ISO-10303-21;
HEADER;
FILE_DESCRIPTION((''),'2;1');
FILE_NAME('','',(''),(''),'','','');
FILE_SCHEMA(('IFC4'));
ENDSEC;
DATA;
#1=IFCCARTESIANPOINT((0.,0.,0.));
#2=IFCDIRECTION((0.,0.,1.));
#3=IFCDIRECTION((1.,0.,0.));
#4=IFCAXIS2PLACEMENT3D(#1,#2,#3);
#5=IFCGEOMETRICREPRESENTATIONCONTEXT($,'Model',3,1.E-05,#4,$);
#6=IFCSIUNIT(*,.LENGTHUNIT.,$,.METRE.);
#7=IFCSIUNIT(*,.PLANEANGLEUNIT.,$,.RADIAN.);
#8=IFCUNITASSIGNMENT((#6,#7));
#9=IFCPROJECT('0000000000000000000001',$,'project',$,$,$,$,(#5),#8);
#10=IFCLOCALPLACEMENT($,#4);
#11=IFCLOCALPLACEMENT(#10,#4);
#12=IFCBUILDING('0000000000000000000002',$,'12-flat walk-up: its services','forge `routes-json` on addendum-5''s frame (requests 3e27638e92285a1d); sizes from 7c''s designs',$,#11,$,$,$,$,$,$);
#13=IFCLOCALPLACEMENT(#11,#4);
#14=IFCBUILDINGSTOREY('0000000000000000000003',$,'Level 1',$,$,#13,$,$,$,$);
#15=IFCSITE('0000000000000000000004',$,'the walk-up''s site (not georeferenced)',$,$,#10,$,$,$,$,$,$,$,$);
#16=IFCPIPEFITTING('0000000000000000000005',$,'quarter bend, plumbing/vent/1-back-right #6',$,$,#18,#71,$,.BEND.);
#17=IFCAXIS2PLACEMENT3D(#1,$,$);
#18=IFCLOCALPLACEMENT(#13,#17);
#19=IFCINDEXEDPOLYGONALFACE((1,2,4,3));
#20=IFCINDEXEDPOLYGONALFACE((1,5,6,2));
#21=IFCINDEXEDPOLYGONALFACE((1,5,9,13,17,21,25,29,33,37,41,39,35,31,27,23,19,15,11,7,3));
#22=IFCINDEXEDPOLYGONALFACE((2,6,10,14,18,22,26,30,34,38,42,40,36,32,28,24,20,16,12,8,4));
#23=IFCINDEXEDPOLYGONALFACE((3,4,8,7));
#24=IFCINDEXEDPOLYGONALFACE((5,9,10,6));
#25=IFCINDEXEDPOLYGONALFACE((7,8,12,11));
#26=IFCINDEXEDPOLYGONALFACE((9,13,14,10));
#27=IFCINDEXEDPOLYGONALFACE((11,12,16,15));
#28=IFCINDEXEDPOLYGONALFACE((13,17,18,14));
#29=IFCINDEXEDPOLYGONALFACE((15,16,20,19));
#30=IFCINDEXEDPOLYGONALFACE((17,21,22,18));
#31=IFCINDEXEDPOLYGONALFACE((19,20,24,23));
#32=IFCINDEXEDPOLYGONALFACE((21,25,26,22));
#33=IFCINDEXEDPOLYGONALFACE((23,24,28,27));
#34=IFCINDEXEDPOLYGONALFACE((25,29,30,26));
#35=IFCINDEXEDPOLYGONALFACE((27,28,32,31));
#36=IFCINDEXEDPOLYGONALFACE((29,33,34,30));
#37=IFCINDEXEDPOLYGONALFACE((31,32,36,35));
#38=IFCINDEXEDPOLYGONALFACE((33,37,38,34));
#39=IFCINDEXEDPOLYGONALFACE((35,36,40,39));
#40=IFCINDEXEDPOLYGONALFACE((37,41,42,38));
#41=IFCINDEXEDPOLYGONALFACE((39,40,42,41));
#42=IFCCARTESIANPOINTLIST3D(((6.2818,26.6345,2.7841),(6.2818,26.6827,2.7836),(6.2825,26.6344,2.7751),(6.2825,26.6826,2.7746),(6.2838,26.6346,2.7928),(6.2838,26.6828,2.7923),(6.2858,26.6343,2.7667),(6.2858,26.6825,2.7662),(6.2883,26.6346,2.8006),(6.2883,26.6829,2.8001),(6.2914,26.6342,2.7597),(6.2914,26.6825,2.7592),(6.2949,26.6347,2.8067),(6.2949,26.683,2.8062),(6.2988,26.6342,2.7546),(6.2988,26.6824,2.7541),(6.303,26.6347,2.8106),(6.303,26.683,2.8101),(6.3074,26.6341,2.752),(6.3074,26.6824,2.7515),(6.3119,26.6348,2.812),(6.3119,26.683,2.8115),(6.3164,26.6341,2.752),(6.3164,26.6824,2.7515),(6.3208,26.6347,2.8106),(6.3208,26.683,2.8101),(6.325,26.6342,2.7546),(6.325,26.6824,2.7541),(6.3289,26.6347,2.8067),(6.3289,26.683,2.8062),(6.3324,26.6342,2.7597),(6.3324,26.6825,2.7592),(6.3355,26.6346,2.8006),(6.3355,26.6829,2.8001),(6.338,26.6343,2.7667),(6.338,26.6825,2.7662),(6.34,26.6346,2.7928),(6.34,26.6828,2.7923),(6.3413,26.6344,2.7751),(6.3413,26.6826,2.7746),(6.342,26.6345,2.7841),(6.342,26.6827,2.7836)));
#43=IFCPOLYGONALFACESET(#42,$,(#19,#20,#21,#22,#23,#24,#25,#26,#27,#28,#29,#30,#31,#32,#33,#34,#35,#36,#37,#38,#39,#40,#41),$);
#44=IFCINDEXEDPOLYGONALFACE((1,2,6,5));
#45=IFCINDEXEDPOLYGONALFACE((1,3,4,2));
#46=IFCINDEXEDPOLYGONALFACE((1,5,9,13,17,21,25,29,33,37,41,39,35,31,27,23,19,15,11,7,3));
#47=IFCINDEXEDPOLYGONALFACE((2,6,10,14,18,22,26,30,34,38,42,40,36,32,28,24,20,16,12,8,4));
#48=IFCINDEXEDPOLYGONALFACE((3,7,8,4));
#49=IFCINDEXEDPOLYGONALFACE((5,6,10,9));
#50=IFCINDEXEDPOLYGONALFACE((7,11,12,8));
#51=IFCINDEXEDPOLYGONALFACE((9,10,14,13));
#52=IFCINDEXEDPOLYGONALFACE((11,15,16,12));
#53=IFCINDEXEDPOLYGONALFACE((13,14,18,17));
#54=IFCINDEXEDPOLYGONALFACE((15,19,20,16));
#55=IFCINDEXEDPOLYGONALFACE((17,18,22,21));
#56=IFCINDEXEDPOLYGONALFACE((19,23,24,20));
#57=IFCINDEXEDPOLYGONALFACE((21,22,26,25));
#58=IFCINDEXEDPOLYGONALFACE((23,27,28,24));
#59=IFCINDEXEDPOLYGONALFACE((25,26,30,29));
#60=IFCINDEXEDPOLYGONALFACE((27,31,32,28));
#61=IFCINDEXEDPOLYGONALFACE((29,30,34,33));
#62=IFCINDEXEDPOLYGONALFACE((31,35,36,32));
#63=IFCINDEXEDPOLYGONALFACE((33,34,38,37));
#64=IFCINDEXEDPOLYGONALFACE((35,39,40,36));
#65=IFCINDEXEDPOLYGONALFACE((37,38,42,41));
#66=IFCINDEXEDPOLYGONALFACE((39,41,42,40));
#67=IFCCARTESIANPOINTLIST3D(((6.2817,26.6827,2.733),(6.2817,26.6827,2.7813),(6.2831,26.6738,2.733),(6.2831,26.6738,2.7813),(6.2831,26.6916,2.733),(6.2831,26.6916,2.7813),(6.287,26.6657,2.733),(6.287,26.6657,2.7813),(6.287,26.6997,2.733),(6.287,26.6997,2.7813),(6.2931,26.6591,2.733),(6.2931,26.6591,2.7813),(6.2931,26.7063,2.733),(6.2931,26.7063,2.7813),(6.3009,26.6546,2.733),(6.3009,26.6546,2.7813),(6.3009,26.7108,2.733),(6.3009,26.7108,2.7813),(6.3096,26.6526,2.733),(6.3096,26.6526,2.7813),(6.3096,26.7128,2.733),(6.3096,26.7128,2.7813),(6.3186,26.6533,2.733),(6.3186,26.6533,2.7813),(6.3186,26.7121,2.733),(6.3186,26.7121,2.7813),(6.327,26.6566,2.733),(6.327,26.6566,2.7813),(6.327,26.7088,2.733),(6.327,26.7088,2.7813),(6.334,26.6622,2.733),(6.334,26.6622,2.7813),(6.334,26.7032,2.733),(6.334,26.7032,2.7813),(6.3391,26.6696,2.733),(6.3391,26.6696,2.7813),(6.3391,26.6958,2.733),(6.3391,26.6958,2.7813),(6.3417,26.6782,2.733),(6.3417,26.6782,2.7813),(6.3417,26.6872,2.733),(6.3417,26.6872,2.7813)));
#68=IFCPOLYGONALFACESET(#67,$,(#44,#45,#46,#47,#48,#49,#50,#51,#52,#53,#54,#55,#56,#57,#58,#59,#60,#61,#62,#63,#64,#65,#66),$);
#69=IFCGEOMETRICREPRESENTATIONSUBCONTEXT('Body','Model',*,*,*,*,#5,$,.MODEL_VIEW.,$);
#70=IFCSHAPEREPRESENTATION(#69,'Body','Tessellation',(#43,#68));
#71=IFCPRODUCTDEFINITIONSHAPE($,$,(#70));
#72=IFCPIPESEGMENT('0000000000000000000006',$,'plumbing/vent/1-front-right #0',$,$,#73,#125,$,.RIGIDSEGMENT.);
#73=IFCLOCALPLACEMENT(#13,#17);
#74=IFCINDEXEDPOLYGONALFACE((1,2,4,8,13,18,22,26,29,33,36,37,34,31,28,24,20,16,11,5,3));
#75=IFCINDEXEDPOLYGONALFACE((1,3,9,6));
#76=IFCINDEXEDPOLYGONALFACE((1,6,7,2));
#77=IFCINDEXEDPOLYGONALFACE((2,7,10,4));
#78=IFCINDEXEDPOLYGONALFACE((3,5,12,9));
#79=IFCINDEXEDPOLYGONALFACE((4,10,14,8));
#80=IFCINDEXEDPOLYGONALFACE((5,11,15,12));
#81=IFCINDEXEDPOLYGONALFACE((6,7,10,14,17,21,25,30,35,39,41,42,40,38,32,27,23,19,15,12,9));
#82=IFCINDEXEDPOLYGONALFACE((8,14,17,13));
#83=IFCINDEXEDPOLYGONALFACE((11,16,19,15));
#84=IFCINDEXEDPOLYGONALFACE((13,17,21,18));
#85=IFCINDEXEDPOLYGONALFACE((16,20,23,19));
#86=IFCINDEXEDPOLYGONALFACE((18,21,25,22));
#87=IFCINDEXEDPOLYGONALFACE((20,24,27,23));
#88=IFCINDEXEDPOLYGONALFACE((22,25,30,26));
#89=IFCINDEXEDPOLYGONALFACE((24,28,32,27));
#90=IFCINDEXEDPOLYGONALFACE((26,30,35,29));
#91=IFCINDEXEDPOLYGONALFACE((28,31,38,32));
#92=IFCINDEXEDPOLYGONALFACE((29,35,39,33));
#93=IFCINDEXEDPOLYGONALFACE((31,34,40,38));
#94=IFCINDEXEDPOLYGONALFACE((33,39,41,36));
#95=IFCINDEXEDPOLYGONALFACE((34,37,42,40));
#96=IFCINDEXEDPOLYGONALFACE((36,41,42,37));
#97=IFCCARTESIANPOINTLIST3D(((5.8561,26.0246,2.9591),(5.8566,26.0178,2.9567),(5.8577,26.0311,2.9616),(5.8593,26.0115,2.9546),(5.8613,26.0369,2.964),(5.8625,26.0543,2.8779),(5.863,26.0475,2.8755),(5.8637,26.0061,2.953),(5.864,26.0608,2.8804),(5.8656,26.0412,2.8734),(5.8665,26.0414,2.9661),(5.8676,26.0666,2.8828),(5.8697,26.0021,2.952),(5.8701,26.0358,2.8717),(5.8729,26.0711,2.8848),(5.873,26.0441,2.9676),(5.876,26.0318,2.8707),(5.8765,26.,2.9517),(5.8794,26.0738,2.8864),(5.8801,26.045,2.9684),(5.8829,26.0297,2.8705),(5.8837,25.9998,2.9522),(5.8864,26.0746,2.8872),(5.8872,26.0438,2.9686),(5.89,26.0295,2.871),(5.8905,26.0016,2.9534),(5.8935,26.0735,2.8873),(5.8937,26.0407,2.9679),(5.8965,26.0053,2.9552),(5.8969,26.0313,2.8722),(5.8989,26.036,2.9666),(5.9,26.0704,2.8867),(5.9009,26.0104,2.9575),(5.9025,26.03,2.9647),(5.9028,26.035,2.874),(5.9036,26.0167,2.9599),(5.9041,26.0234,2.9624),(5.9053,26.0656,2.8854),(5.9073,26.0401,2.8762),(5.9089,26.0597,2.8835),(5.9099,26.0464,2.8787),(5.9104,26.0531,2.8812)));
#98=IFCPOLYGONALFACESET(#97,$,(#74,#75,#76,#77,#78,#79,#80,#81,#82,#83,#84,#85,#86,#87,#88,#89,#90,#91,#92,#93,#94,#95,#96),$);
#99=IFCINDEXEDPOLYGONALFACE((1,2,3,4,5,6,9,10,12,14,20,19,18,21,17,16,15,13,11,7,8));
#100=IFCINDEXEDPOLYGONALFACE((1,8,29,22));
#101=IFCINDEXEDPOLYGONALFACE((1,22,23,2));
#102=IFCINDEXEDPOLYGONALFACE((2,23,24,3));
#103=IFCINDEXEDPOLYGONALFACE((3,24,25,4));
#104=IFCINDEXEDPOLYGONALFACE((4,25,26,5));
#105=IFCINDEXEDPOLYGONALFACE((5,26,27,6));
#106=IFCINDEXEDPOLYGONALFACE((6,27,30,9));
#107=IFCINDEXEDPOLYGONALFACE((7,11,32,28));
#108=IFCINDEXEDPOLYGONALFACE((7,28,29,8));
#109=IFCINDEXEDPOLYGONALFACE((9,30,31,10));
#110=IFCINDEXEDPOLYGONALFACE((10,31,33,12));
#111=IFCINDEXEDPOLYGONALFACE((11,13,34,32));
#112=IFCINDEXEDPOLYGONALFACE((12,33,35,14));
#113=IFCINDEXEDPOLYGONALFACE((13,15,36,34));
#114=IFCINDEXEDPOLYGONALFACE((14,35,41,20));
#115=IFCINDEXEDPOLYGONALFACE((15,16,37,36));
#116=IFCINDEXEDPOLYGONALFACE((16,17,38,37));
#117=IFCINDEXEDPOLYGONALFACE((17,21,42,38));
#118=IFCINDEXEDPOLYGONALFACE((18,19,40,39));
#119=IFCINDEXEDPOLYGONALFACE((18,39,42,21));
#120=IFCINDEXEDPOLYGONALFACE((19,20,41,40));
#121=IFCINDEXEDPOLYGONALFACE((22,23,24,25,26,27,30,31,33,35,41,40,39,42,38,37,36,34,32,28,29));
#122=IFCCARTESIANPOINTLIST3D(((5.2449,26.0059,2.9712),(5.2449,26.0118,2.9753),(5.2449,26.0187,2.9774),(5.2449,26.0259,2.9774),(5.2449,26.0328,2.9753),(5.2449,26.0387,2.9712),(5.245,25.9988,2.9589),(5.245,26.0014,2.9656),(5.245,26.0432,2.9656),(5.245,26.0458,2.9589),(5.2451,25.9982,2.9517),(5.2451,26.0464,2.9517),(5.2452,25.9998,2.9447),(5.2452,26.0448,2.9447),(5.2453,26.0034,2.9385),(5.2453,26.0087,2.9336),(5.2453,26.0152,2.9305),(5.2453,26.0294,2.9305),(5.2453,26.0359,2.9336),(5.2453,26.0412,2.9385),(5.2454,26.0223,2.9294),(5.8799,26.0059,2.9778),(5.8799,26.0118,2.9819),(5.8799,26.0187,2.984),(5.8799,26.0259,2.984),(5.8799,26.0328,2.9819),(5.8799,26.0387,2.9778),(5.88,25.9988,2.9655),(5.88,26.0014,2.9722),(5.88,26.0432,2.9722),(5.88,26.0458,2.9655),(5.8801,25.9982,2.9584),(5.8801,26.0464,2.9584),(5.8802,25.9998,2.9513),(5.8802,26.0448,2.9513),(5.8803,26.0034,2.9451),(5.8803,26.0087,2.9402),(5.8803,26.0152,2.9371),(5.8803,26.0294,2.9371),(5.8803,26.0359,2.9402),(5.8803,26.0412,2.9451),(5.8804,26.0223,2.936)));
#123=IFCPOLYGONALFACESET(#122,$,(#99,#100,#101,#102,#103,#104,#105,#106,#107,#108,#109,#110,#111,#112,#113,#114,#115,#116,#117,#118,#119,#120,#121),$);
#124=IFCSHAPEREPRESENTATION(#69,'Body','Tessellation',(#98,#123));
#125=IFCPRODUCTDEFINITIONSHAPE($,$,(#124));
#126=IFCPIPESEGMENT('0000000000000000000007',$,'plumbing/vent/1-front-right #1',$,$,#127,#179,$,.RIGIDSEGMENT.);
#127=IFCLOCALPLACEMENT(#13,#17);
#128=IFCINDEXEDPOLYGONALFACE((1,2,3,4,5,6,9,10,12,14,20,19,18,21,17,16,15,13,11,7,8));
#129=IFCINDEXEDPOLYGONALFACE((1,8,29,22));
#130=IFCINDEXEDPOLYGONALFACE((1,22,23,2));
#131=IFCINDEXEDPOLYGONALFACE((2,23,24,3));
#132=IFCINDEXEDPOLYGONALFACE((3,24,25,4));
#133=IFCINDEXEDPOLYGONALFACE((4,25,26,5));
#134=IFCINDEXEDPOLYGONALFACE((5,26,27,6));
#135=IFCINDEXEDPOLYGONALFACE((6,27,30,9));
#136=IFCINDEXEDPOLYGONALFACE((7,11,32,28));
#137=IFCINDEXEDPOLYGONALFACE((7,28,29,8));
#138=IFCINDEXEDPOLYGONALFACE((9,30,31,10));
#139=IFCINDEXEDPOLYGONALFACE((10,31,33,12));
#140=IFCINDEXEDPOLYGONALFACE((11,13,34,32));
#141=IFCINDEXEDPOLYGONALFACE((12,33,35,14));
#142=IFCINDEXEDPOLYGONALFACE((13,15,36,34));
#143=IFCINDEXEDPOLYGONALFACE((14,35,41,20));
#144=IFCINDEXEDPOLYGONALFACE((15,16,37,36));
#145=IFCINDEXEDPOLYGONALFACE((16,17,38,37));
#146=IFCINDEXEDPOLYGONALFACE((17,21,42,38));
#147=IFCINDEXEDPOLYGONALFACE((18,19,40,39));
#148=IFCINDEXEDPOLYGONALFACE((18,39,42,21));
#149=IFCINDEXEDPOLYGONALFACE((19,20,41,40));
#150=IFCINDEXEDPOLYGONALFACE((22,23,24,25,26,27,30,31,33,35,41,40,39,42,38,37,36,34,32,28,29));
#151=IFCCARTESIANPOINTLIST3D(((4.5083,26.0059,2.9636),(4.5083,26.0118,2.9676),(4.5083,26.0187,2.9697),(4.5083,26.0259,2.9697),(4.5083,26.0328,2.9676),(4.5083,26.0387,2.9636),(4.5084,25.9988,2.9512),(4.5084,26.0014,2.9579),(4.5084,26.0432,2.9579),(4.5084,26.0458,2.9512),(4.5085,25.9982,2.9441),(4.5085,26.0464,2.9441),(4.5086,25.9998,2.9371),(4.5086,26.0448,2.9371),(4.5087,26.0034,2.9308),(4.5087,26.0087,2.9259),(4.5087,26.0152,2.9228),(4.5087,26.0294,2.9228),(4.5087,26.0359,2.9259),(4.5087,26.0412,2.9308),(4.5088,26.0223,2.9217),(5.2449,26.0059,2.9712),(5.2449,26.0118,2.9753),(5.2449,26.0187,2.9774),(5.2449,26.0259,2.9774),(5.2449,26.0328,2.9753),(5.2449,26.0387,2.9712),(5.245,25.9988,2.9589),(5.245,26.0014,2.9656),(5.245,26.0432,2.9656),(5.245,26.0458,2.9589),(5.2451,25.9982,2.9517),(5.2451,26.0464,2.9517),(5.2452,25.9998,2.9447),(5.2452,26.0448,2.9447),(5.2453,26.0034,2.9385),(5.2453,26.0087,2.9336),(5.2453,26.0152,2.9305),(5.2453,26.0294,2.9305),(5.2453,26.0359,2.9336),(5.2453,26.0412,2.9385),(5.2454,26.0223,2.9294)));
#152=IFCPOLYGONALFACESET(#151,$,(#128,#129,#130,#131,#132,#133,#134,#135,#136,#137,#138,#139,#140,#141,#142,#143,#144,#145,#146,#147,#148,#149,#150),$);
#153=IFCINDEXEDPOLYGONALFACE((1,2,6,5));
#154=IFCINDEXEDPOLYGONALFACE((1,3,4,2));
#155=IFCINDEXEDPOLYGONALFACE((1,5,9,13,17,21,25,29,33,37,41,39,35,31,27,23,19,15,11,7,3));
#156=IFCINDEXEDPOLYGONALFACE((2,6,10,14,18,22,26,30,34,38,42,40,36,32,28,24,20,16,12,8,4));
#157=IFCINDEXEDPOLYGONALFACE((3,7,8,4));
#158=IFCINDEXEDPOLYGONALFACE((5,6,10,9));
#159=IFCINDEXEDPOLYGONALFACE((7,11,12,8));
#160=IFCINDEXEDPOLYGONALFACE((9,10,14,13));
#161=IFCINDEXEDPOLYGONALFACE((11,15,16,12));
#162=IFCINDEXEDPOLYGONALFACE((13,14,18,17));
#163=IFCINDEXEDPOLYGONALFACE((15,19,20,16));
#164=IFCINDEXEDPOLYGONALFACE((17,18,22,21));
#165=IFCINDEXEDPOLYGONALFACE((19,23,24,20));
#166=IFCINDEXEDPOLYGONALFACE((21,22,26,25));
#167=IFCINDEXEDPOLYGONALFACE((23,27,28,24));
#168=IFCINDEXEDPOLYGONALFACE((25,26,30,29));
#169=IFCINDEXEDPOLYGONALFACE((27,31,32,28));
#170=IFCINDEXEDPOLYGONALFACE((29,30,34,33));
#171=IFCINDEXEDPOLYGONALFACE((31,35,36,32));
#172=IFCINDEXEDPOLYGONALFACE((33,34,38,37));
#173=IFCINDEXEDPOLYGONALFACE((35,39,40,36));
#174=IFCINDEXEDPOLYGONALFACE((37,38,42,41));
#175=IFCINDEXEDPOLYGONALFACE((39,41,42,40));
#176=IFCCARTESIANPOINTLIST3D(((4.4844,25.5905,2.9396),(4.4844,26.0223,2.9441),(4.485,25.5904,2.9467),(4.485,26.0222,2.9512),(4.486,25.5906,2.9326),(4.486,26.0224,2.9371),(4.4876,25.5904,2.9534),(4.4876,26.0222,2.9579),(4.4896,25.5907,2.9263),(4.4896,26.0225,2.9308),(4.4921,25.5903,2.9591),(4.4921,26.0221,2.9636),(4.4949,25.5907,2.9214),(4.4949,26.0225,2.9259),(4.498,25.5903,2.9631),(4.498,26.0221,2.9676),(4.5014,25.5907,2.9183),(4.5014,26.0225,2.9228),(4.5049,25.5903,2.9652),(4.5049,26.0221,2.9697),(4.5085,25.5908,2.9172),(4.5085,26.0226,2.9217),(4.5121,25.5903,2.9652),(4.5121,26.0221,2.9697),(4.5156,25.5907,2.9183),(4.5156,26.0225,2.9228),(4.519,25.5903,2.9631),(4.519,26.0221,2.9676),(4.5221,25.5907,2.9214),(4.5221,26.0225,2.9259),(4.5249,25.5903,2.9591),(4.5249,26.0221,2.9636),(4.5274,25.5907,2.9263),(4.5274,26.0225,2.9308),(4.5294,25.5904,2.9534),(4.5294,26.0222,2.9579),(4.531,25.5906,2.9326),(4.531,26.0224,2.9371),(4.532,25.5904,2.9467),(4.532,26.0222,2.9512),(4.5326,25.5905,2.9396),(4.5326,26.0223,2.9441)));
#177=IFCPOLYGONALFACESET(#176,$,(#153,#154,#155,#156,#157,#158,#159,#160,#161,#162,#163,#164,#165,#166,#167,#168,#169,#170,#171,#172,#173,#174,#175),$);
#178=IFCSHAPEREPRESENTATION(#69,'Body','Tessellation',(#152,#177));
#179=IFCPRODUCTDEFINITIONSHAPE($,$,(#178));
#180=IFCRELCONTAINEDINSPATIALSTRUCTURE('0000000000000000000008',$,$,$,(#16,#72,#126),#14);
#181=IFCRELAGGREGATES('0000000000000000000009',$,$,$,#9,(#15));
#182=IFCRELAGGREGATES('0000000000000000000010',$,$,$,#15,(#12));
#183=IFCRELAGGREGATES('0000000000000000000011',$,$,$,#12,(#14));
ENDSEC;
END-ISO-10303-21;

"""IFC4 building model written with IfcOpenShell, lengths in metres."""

from ifc_helpers import new_model, entity, si_unit, frame, origin_with_axes, place, context, subcontext, project, spatial, element, save


model = new_model("IFC4")

# Units and contexts
model_context = context("Model", 3, precision=1e-05, world=origin_with_axes())
body_context = subcontext(model_context, "Body", "Model", "MODEL_VIEW")
ifc_project = project(units=[si_unit("LENGTHUNIT", "METRE"), si_unit("PLANEANGLEUNIT", "RADIAN")], contexts=[model_context])

# Site, building, storey
site_placement = place(None, origin_with_axes())
site = spatial("IfcSite", under=ifc_project, at=site_placement, Name="the walk-up's site (not georeferenced)")
building_placement = place(site_placement, origin_with_axes())
building = spatial("IfcBuilding", under=site, at=building_placement, Name="12-flat walk-up: its services", Description="forge `routes-json` on addendum-5's frame (requests 3e27638e92285a1d); sizes from 7c's designs")
storey_placement = place(building_placement, origin_with_axes())
storey = spatial("IfcBuildingStorey", under=building, at=storey_placement, Name="Level 1")

# Pipe fitting
pipe_fitting_1_placement = place(storey_placement, frame((6.3119, 26.6344, 2.7818), z_axis=(0.0, 0.0, 1.0), x_axis=(1.0, 0.0, 0.0)))
element("IfcPipeFitting", 1, at=pipe_fitting_1_placement, inside=storey, Name="quarter bend, plumbing/vent/1-back-right #6", PredefinedType="BEND", context=body_context, shape_type="AdvancedSweptSolid", body=[
    entity("IfcSweptDiskSolid", entity("IfcPolyline", [entity("IfcCartesianPoint", [0.0, 0.0, 0.0]), entity("IfcCartesianPoint", [0.0, 0.0483, -0.0005])]), 0.0302),
    entity("IfcSweptDiskSolid", entity("IfcPolyline", [entity("IfcCartesianPoint", [0.0, 0.0483, -0.0005]), entity("IfcCartesianPoint", [0.0, 0.0483, -0.0488])]), 0.0302),
])

# Pipe segments
pipe_segment_1_placement = place(storey_placement, frame((5.8864, 26.052, 2.8789), z_axis=(0.0, 0.0, 1.0), x_axis=(1.0, 0.0, 0.0)))
element("IfcPipeSegment", 2, at=pipe_segment_1_placement, inside=storey, Name="plumbing/vent/1-front-right #0", PredefinedType="RIGIDSEGMENT", context=body_context, shape_type="AdvancedSweptSolid", body=[
    entity("IfcSweptDiskSolid", entity("IfcPolyline", [entity("IfcCartesianPoint", [0.0, 0.0, 0.0]), entity("IfcCartesianPoint", [-0.0064, -0.0297, 0.0812])]), 0.0241),
    entity("IfcSweptDiskSolid", entity("IfcPolyline", [entity("IfcCartesianPoint", [-0.0064, -0.0297, 0.0812]), entity("IfcCartesianPoint", [-0.6414, -0.0297, 0.0746])]), 0.0241),
])
pipe_segment_2_placement = place(storey_placement, frame((5.2451, 26.0223, 2.9535), z_axis=(0.0, 0.0, 1.0), x_axis=(1.0, 0.0, 0.0)))
element("IfcPipeSegment", 3, at=pipe_segment_2_placement, inside=storey, Name="plumbing/vent/1-front-right #1", PredefinedType="RIGIDSEGMENT", context=body_context, shape_type="AdvancedSweptSolid", body=[
    entity("IfcSweptDiskSolid", entity("IfcPolyline", [entity("IfcCartesianPoint", [0.0, 0.0, 0.0]), entity("IfcCartesianPoint", [-0.7366, 0.0, -0.0077])]), 0.0241),
    entity("IfcSweptDiskSolid", entity("IfcPolyline", [entity("IfcCartesianPoint", [-0.7366, 0.0, -0.0077]), entity("IfcCartesianPoint", [-0.7366, -0.4318, -0.0122])]), 0.0241),
])

save(model, "model.ifc")
